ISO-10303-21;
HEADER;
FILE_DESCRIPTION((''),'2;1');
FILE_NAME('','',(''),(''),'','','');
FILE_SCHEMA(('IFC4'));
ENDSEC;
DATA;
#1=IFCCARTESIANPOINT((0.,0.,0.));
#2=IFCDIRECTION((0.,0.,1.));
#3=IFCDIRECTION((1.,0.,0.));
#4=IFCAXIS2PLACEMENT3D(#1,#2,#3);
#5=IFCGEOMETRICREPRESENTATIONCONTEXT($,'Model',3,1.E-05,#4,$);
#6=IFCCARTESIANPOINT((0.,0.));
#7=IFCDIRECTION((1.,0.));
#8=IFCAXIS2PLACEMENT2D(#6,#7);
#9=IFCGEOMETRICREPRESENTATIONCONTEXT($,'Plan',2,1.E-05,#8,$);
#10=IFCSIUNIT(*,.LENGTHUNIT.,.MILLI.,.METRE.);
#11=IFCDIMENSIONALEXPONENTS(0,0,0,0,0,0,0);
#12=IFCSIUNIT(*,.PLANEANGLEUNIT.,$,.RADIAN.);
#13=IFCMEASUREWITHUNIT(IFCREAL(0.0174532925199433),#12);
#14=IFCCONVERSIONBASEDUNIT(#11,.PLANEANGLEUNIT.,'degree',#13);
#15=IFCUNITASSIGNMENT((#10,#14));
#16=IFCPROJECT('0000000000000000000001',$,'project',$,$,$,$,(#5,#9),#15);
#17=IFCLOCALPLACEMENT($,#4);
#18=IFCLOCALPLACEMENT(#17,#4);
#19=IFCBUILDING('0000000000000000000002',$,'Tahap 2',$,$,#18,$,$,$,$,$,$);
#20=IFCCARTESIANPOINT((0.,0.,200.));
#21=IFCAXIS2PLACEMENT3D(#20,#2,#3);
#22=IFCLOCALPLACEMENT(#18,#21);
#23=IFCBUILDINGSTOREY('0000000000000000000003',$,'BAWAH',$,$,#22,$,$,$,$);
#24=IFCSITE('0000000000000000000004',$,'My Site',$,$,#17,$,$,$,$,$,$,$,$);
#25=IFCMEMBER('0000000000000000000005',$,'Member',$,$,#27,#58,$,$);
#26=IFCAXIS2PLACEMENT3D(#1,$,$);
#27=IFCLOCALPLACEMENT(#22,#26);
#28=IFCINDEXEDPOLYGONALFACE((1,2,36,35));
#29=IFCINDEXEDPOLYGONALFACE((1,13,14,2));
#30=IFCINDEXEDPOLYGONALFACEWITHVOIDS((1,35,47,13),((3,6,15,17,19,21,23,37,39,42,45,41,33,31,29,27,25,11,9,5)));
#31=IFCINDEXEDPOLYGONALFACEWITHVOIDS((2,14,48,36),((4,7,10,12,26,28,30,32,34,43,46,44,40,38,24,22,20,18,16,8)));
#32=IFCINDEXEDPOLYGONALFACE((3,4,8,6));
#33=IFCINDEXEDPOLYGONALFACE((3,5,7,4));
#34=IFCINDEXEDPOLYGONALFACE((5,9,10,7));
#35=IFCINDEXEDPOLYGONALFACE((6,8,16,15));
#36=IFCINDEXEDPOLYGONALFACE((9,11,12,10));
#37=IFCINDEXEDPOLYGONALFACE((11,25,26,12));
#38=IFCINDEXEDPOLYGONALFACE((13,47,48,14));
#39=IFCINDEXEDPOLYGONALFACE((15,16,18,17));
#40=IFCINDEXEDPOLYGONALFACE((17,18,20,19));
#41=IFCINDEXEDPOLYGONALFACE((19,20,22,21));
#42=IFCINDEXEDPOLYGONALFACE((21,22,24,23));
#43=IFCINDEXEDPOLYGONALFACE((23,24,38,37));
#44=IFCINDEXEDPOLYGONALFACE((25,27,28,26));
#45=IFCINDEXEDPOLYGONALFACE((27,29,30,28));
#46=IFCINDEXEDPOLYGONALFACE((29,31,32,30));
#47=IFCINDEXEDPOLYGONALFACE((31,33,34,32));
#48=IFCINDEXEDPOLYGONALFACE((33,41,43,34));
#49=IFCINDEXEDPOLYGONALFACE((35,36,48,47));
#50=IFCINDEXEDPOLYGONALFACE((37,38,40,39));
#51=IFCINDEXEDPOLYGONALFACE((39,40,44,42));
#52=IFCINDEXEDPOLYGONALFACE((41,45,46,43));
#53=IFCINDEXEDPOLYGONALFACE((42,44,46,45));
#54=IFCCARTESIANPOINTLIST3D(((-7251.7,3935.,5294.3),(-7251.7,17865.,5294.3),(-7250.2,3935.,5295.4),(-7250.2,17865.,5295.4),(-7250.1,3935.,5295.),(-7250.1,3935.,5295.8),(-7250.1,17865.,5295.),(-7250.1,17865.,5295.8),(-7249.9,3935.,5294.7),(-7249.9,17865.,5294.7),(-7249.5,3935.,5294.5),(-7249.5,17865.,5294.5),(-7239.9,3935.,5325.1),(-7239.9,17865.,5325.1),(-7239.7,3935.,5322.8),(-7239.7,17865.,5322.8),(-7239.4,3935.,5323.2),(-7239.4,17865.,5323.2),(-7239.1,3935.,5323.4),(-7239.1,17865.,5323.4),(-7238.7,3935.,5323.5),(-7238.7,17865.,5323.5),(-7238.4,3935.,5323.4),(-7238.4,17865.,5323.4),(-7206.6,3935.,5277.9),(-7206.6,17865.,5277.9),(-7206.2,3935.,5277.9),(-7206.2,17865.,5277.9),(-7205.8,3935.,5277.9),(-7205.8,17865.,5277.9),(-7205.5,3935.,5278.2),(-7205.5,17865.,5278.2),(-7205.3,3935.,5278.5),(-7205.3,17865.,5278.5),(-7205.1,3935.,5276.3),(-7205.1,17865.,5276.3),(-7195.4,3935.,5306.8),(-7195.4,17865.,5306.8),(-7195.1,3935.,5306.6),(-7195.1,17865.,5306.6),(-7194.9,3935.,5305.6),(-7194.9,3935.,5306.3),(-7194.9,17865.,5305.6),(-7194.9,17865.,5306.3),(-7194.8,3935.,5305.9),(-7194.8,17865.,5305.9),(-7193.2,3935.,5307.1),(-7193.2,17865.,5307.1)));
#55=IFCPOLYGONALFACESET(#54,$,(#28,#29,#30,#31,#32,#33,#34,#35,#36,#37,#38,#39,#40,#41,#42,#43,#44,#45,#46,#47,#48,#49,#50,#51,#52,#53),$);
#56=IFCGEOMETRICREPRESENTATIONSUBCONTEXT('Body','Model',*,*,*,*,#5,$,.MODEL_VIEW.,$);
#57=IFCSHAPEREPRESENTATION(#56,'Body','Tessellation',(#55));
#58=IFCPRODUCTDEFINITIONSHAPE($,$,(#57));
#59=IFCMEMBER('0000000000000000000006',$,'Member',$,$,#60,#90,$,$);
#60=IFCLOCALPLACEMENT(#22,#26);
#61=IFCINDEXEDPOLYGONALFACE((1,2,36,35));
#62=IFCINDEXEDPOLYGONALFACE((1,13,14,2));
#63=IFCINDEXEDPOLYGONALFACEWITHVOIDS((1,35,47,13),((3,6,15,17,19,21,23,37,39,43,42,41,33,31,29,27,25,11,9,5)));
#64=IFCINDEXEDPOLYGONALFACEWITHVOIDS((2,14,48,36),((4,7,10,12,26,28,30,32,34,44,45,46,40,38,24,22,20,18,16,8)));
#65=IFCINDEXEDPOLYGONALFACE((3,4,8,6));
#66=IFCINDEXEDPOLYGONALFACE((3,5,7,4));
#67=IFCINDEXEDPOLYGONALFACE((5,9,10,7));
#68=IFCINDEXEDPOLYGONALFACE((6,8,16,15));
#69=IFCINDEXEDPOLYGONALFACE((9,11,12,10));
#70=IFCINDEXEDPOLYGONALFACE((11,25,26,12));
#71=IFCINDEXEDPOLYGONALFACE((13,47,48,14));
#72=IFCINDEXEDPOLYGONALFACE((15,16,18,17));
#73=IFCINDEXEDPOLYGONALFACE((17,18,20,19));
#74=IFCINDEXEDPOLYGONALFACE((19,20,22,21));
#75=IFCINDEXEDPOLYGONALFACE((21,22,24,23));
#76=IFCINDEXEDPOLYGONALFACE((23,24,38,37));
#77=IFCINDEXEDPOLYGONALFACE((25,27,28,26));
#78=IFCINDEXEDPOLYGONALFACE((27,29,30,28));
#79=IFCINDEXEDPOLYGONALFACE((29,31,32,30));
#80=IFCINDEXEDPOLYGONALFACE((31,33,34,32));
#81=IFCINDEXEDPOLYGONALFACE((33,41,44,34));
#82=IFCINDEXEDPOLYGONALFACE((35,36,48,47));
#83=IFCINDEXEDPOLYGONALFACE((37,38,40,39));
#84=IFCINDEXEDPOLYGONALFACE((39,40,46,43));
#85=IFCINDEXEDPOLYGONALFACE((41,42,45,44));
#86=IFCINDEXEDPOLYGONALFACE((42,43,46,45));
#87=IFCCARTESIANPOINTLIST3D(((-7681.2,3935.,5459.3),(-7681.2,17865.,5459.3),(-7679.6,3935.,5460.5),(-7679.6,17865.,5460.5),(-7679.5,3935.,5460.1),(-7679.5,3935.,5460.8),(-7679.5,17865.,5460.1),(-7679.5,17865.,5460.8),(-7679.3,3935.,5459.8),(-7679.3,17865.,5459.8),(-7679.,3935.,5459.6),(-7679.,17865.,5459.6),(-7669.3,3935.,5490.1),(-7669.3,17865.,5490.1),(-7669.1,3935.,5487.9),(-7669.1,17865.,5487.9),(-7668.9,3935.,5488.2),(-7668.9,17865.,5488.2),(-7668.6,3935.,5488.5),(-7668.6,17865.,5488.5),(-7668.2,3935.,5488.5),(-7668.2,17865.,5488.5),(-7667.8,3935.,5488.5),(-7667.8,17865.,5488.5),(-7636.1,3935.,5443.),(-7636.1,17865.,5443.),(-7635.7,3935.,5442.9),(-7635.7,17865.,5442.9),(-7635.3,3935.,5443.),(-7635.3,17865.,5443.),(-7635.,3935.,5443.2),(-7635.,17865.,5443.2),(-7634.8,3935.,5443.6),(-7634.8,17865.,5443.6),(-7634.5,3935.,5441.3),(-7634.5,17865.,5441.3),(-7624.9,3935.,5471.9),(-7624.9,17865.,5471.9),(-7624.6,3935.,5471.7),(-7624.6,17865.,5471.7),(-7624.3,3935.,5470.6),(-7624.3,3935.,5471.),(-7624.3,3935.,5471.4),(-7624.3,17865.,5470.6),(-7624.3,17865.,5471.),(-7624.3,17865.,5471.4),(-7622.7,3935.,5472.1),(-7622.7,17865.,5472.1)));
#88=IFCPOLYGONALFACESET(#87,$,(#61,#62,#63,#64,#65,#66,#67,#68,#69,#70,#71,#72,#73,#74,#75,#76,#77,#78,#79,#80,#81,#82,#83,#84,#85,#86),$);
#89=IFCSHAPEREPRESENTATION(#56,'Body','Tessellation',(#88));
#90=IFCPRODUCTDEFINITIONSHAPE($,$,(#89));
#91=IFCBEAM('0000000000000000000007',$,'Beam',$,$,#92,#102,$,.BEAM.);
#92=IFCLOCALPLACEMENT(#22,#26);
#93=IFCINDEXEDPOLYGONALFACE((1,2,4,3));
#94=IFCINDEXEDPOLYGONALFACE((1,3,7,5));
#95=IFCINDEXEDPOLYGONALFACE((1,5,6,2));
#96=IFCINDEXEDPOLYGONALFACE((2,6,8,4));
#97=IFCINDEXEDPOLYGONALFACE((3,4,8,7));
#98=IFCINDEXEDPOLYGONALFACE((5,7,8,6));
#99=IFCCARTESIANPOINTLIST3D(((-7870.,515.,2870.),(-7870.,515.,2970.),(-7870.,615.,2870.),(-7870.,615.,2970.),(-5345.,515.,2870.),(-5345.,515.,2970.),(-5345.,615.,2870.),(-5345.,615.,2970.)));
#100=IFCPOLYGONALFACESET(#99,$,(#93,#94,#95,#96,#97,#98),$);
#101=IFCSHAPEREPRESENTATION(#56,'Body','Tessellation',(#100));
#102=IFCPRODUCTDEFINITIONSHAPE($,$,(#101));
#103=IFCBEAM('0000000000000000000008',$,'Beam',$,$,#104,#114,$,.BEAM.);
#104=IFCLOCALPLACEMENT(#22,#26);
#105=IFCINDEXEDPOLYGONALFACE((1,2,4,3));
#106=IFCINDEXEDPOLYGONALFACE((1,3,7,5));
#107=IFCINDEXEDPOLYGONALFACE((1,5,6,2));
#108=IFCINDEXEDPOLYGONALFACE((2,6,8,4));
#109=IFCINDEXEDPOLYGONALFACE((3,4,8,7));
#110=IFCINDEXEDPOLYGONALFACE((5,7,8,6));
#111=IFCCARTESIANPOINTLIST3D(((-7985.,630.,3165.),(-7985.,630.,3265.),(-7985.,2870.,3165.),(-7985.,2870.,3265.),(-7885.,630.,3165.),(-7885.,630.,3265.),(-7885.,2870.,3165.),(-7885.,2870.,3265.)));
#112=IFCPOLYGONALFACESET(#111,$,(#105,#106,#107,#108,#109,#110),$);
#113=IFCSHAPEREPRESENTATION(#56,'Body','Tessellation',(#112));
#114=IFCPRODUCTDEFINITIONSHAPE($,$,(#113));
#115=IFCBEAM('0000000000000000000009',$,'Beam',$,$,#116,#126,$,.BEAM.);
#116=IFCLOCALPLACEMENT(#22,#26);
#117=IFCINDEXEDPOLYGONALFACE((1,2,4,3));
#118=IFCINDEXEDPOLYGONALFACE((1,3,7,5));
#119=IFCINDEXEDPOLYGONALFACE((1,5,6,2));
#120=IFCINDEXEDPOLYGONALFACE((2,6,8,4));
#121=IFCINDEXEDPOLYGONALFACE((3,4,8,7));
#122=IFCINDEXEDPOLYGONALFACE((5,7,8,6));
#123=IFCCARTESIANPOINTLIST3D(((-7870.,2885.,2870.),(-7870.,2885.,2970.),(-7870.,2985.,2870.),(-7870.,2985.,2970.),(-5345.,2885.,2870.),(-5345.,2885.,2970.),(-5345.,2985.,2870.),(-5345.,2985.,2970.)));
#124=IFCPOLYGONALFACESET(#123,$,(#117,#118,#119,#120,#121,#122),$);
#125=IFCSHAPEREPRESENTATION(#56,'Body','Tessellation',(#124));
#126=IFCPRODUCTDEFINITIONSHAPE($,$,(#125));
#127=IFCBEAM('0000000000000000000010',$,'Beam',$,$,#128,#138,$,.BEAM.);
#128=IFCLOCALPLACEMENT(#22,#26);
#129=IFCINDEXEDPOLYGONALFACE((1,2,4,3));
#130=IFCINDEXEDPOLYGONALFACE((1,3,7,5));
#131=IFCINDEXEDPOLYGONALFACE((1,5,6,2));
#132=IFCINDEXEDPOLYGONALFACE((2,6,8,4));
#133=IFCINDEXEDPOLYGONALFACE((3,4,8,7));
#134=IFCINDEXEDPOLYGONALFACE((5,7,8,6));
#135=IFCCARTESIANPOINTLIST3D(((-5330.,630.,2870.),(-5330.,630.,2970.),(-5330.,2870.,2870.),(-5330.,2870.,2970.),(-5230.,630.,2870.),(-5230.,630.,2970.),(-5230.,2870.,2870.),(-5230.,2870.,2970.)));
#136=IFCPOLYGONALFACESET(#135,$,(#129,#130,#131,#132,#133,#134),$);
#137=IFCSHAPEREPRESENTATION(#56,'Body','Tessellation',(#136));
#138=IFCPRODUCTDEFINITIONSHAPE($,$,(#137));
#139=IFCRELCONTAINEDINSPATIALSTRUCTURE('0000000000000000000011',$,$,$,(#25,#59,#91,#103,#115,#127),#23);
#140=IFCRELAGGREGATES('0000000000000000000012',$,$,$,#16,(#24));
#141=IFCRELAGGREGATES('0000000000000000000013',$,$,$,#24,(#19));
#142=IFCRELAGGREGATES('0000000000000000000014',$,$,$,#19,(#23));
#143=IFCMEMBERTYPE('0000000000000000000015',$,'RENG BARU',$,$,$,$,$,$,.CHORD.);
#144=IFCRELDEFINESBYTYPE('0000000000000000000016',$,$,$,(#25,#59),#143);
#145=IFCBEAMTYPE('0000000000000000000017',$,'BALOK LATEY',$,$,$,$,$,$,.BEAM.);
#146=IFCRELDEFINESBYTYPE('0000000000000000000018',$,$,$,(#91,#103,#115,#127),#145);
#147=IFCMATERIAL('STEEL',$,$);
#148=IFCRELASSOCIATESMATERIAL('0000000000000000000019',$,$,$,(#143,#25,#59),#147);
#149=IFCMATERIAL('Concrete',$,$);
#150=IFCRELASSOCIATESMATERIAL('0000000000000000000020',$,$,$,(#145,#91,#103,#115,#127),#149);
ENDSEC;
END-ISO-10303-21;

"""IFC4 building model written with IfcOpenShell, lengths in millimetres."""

from ifc_helpers import new_model, entity, si_unit, converted_unit, frame, origin_with_axes, origin_2d_with_axis, place, context, subcontext, project, spatial, rectangle, hollow_rectangle, extrude, material, material_profile, profile_set, profile_usage, type_object, element, save


model = new_model("IFC4")

# Units and contexts
model_context = context("Model", 3, precision=1e-05, world=origin_with_axes())
plan_context = context("Plan", 2, precision=1e-05, world=origin_2d_with_axis())
body_context = subcontext(model_context, "Body", "Model", "MODEL_VIEW")
ifc_project = project(units=[si_unit("LENGTHUNIT", "METRE", prefix="MILLI"), converted_unit("PLANEANGLEUNIT", "degree", entity("IfcReal", 0.0174532925199433), si_unit("PLANEANGLEUNIT", "RADIAN"), dimensions=[0, 0, 0, 0, 0, 0, 0])], contexts=[model_context, plan_context])

# Site, building, storey
site_placement = place(None, origin_with_axes())
site = spatial("IfcSite", under=ifc_project, at=site_placement, Name="My Site")
building_placement = place(site_placement, origin_with_axes())
building = spatial("IfcBuilding", under=site, at=building_placement, Name="Tahap 2")
storey_placement = place(building_placement, frame((0.0, 0.0, 200.0), z_axis=(0.0, 0.0, 1.0), x_axis=(1.0, 0.0, 0.0)))
storey = spatial("IfcBuildingStorey", under=building, at=storey_placement, Name="BAWAH")

# Shared definitions
ifc_material_1 = material(Name="Concrete")

# Members
ifc_material_2 = material(Name="STEEL")
ifc_material_profile_1 = material_profile(ifc_material_2, hollow_rectangle(XDim=50.0, YDim=33.0, WallThickness=1.0, InnerFilletRadius=1.0, OuterFilletRadius=0.0, kind="CURVE"))
ifc_profile_set_1 = profile_set([ifc_material_profile_1])
member_type_1 = type_object("IfcMemberType", Name="RENG BARU", PredefinedType="CHORD", material=ifc_profile_set_1)
ifc_profile_usage_1 = profile_usage(ifc_profile_set_1, cardinal=3)
member_1_placement = place(storey_placement, frame((-7205.1, 3935.0, 5276.3), z_axis=(0.0, 1.0, 0.0), x_axis=(-0.932954, 0.0, 0.359997)))
element("IfcMember", 1, at=member_1_placement, inside=storey, type_object=member_type_1, material=ifc_profile_usage_1, Name="Member", context=body_context, shape_type="SweptSolid", body=[
    extrude(hollow_rectangle(XDim=50.0, YDim=33.0, WallThickness=1.0, InnerFilletRadius=1.0, OuterFilletRadius=0.0, kind="CURVE"), frame((25.0, 16.5, 0.0), z_axis=(0.0, 0.0, 1.0), x_axis=(1.0, 0.0, 0.0)), (0.0, 0.0, 1.0), 13930.0),
])
ifc_profile_usage_2 = profile_usage(ifc_profile_set_1, cardinal=3)
member_2_placement = place(storey_placement, frame((-7634.5, 3935.0, 5441.3), z_axis=(0.0, 1.0, 0.0), x_axis=(-0.932954, 0.0, 0.359997)))
element("IfcMember", 2, at=member_2_placement, inside=storey, type_object=member_type_1, material=ifc_profile_usage_2, Name="Member", context=body_context, shape_type="SweptSolid", body=[
    extrude(hollow_rectangle(XDim=50.0, YDim=33.0, WallThickness=1.0, InnerFilletRadius=1.0, OuterFilletRadius=0.0, kind="CURVE"), frame((25.0, 16.5, 0.0), z_axis=(0.0, 0.0, 1.0), x_axis=(1.0, 0.0, 0.0)), (0.0, 0.0, 1.0), 13930.0),
])

# Beams
ifc_material_profile_2 = material_profile(ifc_material_1, rectangle(XDim=100.0, YDim=100.0))
ifc_profile_set_2 = profile_set([ifc_material_profile_2])
ifc_profile_usage_3 = profile_usage(ifc_profile_set_2, cardinal=2)
beam_type_1 = type_object("IfcBeamType", Name="BALOK LATEY", PredefinedType="BEAM", material=ifc_profile_set_2)
beam_1_placement = place(storey_placement, frame((-5345.0, 565.0, 2870.0), z_axis=(-1.0, 0.0, 0.0), x_axis=(0.0, -1.0, 0.0)))
element("IfcBeam", 3, at=beam_1_placement, inside=storey, type_object=beam_type_1, material=ifc_profile_usage_3, Name="Beam", PredefinedType="BEAM", context=body_context, shape_type="SweptSolid", body=[
    extrude(rectangle(XDim=100.0, YDim=100.0), frame((0.0, 50.0, 0.0), z_axis=(0.0, 0.0, 1.0), x_axis=(1.0, 0.0, 0.0)), (0.0, 0.0, 1.0), 2525.0),
])
ifc_profile_usage_4 = profile_usage(ifc_profile_set_2, cardinal=2)
beam_2_placement = place(storey_placement, frame((-7935.0, 630.0, 3165.0), z_axis=(0.0, 1.0, 0.0), x_axis=(-1.0, 0.0, 0.0)))
element("IfcBeam", 4, at=beam_2_placement, inside=storey, type_object=beam_type_1, material=ifc_profile_usage_4, Name="Beam", PredefinedType="BEAM", context=body_context, shape_type="SweptSolid", body=[
    extrude(rectangle(XDim=100.0, YDim=100.0), frame((0.0, 50.0, 0.0), z_axis=(0.0, 0.0, 1.0), x_axis=(1.0, 0.0, 0.0)), (0.0, 0.0, 1.0), 2240.0),
])
ifc_profile_usage_5 = profile_usage(ifc_profile_set_2, cardinal=2)
beam_3_placement = place(storey_placement, frame((-7870.0, 2935.0, 2870.0), z_axis=(1.0, -0.000001, 0.000001), x_axis=(0.000001, 1.0, 0.0)))
element("IfcBeam", 5, at=beam_3_placement, inside=storey, type_object=beam_type_1, material=ifc_profile_usage_5, Name="Beam", PredefinedType="BEAM", context=body_context, shape_type="SweptSolid", body=[
    extrude(rectangle(XDim=100.0, YDim=100.0), frame((0.0, 50.0, 0.0), z_axis=(0.0, 0.0, 1.0), x_axis=(1.0, 0.0, 0.0)), (0.0, 0.0, 1.0), 2525.0),
])
ifc_profile_usage_6 = profile_usage(ifc_profile_set_2, cardinal=2)
beam_4_placement = place(storey_placement, frame((-5280.0, 630.0, 2870.0), z_axis=(0.000001, 1.0, 0.0), x_axis=(-1.0, 0.000001, 0.0)))
element("IfcBeam", 6, at=beam_4_placement, inside=storey, type_object=beam_type_1, material=ifc_profile_usage_6, Name="Beam", PredefinedType="BEAM", context=body_context, shape_type="SweptSolid", body=[
    extrude(rectangle(XDim=100.0, YDim=100.0), frame((0.0, 50.0, 0.0), z_axis=(0.0, 0.0, 1.0), x_axis=(1.0, 0.0, 0.0)), (0.0, 0.0, 1.0), 2240.0),
])

save(model, "model.ifc")
